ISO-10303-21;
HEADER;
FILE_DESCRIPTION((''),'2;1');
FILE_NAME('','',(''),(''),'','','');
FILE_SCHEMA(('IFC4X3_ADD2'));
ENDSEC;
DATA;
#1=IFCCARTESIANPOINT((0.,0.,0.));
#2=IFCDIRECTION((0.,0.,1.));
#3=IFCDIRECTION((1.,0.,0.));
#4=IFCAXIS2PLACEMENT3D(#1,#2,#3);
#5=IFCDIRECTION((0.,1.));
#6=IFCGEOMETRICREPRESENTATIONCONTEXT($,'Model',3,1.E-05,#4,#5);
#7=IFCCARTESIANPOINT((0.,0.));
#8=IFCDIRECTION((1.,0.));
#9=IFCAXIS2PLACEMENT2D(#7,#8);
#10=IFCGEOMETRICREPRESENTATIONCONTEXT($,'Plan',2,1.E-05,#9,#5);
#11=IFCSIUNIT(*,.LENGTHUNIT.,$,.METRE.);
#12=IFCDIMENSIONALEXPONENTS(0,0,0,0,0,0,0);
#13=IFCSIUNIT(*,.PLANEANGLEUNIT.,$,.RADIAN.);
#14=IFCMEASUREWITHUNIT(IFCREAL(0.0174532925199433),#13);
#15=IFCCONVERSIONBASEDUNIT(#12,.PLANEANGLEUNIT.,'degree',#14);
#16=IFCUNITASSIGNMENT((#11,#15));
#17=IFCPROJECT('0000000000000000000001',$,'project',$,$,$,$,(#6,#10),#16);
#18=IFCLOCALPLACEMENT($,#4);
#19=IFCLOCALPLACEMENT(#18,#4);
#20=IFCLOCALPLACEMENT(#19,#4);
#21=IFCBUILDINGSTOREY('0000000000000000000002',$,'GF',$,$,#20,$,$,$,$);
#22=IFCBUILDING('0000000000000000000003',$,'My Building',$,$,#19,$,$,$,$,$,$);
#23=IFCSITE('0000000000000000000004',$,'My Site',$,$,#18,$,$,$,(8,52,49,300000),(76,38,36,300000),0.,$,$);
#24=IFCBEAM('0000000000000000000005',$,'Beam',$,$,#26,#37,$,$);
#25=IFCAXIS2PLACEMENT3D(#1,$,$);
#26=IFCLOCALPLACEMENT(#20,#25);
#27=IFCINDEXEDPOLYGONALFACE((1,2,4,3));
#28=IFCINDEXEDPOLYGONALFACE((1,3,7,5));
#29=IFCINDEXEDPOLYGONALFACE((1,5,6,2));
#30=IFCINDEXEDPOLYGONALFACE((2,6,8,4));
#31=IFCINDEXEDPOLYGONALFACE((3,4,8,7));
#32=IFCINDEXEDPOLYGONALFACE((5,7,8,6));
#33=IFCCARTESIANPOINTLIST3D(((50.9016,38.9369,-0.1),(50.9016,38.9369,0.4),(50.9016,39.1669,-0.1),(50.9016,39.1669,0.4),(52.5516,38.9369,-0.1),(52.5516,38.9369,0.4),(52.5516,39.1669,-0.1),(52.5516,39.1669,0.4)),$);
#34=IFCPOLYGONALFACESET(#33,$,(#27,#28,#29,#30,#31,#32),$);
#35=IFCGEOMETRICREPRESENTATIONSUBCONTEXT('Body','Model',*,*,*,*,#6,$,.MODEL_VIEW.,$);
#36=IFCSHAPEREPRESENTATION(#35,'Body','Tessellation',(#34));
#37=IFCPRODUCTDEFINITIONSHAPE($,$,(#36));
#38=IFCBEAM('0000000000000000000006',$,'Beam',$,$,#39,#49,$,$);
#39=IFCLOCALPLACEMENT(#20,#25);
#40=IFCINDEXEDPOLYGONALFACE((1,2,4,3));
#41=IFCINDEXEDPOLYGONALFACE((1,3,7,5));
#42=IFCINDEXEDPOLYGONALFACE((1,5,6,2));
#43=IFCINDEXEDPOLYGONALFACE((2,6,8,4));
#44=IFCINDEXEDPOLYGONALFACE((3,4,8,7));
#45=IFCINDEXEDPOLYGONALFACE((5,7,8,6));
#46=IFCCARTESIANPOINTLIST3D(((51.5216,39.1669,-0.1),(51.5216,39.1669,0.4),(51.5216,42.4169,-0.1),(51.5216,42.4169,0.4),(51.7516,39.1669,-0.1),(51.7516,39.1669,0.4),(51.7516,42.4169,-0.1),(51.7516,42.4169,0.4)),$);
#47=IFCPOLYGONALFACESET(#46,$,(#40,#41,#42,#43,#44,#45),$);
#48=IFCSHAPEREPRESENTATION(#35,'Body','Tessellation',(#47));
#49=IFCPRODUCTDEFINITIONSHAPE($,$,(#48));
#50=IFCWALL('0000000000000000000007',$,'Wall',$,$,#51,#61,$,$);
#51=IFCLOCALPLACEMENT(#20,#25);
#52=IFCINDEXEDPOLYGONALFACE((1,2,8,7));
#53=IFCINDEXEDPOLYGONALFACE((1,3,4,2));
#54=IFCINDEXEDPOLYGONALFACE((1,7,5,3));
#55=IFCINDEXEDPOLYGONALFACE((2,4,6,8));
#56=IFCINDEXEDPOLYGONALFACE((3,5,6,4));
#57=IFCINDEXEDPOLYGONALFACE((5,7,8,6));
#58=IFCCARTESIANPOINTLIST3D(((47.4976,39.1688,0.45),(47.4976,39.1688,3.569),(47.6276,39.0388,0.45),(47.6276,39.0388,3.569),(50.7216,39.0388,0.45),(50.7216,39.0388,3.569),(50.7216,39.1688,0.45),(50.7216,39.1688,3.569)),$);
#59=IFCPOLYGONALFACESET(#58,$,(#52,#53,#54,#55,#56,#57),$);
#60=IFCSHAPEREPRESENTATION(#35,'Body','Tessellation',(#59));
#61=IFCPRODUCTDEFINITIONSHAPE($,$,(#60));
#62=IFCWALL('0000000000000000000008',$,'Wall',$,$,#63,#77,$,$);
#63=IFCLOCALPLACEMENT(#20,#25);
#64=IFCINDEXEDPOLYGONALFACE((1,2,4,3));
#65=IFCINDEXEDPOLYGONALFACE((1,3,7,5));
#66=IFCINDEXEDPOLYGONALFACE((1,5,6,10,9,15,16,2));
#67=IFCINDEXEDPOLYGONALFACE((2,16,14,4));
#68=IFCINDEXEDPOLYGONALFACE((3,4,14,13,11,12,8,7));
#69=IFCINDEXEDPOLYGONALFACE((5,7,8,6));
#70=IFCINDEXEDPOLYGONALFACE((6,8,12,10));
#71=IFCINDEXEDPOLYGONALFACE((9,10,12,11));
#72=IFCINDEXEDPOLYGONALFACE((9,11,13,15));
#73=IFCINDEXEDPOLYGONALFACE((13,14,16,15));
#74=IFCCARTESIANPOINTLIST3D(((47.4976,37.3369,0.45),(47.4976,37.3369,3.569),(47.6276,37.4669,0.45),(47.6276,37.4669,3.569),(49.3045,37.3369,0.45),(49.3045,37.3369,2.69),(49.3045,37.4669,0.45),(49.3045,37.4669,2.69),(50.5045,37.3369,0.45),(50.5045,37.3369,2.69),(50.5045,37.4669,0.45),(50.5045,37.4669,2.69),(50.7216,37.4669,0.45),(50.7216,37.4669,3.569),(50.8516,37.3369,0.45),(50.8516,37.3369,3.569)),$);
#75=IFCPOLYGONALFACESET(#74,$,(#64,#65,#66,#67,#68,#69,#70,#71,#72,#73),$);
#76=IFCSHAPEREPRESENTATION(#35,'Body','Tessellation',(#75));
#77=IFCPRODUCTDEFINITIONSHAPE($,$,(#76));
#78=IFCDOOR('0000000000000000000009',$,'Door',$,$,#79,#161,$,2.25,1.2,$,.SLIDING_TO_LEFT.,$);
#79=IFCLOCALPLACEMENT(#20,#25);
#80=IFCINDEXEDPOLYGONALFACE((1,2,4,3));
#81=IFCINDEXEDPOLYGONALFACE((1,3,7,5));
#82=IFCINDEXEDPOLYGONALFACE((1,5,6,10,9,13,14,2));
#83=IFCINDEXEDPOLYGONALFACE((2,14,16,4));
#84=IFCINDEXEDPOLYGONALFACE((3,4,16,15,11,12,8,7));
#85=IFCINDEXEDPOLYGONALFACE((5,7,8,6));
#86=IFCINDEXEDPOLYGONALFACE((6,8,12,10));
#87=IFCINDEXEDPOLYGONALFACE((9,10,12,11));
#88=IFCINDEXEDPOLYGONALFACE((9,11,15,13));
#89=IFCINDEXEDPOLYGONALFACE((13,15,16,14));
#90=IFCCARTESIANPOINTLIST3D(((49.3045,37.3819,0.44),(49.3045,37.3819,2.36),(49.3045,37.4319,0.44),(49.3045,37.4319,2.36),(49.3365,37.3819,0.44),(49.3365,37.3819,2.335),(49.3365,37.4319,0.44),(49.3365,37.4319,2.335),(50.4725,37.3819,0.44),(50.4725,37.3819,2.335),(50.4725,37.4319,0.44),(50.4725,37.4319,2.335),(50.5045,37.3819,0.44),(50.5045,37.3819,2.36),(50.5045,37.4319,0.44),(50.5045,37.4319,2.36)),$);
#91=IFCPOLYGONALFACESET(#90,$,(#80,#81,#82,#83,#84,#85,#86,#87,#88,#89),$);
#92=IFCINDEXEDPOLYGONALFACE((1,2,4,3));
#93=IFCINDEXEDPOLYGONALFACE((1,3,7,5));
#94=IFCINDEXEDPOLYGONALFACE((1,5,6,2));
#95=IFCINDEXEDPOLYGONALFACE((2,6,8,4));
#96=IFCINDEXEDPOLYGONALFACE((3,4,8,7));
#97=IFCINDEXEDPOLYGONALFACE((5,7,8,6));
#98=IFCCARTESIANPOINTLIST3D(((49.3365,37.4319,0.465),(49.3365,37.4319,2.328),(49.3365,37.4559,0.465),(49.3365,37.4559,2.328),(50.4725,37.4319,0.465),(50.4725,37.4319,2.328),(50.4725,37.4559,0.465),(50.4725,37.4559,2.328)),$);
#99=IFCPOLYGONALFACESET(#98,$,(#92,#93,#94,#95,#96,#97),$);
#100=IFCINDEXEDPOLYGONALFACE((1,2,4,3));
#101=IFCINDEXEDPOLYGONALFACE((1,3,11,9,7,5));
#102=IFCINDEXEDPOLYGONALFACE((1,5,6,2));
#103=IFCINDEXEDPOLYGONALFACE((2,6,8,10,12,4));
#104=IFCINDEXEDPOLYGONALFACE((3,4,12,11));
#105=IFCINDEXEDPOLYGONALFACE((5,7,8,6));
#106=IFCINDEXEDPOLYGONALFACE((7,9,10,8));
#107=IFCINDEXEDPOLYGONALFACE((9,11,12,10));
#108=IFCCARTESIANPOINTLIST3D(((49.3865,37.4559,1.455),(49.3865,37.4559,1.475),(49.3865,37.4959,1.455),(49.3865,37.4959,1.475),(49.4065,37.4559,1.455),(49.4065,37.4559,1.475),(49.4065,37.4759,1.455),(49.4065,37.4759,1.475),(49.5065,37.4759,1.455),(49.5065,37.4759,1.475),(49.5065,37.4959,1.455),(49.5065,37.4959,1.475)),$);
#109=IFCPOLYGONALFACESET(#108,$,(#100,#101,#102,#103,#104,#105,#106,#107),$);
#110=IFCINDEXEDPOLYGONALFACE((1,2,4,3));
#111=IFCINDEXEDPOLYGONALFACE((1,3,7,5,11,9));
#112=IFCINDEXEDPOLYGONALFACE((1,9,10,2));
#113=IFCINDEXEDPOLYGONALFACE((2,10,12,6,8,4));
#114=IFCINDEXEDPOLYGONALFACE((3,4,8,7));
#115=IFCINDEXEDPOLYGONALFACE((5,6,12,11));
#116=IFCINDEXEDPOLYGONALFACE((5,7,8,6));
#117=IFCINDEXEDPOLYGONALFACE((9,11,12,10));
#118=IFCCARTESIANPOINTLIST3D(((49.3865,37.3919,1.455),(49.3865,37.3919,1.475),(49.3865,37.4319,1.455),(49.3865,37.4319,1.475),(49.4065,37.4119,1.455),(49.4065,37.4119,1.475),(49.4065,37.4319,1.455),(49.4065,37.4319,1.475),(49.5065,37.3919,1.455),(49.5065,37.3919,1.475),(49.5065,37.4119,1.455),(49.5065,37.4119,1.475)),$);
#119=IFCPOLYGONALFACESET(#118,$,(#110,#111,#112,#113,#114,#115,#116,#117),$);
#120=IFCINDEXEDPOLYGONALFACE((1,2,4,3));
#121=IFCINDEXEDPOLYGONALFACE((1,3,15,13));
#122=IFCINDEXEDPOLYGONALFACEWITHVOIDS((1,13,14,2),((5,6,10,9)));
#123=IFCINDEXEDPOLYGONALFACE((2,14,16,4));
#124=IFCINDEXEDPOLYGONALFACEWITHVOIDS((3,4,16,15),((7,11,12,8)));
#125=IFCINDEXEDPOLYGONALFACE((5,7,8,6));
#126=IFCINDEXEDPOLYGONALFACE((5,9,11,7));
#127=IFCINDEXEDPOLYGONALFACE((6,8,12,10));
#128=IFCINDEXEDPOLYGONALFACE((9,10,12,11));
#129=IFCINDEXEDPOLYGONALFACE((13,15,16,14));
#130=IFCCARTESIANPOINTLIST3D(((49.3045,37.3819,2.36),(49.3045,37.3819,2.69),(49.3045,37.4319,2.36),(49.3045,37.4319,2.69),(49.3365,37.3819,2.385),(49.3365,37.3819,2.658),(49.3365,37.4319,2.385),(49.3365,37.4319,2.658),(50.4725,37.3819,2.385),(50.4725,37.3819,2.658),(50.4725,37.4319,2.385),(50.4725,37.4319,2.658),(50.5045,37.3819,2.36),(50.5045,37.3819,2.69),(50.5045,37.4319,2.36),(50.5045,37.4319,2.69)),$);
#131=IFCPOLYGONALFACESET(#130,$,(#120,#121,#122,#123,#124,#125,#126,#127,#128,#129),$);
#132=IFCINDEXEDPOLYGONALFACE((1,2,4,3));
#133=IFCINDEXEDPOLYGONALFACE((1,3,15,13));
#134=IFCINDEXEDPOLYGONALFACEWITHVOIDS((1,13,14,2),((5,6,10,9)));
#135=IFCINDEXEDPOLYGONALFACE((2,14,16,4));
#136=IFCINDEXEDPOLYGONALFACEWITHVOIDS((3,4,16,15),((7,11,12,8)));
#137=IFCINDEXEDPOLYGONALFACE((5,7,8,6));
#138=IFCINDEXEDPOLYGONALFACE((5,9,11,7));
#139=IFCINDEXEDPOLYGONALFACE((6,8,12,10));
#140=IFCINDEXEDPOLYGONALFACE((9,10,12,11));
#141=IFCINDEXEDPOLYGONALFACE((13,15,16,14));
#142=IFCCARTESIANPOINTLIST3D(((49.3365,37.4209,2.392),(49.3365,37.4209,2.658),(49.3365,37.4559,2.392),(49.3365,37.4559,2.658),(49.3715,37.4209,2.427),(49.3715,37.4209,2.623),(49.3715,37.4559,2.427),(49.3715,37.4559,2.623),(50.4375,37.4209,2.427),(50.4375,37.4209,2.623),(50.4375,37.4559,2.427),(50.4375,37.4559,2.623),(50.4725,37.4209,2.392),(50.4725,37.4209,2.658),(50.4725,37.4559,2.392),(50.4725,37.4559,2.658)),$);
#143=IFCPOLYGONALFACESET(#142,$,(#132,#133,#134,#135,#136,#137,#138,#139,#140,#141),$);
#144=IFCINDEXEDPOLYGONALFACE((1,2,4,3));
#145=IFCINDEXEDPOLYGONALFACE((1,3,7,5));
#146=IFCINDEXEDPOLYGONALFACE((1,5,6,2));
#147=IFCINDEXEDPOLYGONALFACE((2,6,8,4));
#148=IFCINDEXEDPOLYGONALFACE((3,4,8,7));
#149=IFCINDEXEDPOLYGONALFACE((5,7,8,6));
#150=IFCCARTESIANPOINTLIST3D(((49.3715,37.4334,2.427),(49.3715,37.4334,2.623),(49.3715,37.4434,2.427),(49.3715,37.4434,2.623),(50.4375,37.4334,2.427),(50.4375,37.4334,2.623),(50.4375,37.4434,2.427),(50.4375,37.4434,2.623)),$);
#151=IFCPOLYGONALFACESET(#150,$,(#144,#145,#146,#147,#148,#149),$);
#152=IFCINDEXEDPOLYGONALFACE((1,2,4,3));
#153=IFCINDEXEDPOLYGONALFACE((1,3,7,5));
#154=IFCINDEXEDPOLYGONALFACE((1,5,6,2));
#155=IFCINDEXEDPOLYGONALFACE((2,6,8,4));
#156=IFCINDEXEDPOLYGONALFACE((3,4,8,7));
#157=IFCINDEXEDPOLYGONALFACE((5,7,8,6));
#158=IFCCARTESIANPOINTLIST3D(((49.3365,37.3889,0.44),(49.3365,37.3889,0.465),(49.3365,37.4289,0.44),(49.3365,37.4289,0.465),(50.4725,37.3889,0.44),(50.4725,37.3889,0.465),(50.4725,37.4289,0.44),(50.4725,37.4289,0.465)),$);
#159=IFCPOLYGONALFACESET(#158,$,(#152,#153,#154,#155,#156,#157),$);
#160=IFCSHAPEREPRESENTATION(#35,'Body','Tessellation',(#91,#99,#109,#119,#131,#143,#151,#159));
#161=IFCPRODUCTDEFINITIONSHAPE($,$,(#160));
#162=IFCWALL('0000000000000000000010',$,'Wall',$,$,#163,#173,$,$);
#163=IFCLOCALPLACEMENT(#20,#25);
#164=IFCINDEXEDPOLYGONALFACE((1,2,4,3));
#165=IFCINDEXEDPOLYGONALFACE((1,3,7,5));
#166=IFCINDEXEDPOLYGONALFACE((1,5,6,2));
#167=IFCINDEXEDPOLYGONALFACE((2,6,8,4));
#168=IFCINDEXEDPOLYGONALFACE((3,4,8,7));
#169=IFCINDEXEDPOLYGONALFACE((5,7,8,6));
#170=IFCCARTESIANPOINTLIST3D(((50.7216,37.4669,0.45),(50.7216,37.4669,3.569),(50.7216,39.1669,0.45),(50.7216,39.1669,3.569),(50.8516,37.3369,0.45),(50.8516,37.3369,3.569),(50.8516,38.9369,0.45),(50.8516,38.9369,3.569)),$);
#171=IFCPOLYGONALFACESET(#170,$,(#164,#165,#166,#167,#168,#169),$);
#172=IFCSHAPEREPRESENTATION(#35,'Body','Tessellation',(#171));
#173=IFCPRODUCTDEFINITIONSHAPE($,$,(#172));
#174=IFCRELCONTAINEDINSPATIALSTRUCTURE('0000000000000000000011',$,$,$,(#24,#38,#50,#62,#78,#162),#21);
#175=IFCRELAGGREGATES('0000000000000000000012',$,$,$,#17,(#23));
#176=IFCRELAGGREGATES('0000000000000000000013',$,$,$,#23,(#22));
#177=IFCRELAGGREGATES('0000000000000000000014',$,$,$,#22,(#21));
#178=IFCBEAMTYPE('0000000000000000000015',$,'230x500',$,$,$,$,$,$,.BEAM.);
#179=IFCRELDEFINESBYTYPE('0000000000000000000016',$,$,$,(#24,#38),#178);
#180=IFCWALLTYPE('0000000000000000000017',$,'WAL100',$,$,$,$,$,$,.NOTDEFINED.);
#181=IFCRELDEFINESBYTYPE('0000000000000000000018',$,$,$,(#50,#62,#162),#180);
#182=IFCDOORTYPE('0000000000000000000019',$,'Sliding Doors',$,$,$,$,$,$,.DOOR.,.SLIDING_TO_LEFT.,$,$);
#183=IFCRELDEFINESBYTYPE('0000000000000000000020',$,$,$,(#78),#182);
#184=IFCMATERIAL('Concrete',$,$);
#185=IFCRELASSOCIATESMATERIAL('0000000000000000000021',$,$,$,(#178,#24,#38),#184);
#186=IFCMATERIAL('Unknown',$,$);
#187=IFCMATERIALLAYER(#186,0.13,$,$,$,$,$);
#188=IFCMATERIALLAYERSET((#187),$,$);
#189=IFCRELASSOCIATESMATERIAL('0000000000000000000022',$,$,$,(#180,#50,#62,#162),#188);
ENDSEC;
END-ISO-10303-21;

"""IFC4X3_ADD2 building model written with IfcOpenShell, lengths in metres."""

from ifc_helpers import new_model, entity, si_unit, converted_unit, direction, frame, origin_with_axes, origin_2d_with_axis, place, context, subcontext, project, spatial, line, indexed_curve, rectangle, outline, extrude, shape, source, transform, mapped, material, layer, layer_set, layer_usage, material_profile, profile_set, profile_usage, type_object, type_shapes, element, fill, save


model = new_model("IFC4X3_ADD2")

# Units and contexts
model_context = context("Model", 3, precision=1e-05, world=origin_with_axes(), true_north=direction((0.0, 1.0)))
plan_context = context("Plan", 2, precision=1e-05, world=origin_2d_with_axis(), true_north=direction((0.0, 1.0)))
body_context_1 = subcontext(model_context, "Body", "Model", "MODEL_VIEW")
body_context_2 = subcontext(plan_context, "Body", "Plan", "PLAN_VIEW")
ifc_project = project(units=[si_unit("LENGTHUNIT", "METRE"), converted_unit("PLANEANGLEUNIT", "degree", entity("IfcReal", 0.0174532925199433), si_unit("PLANEANGLEUNIT", "RADIAN"), dimensions=[0, 0, 0, 0, 0, 0, 0])], contexts=[model_context, plan_context])

# Site, building, storey
site_placement = place(None, origin_with_axes())
site = spatial("IfcSite", under=ifc_project, at=site_placement, Name="My Site", RefLatitude=(8, 52, 49, 300000), RefLongitude=(76, 38, 36, 300000), RefElevation=0.0)
building_placement = place(site_placement, origin_with_axes())
building = spatial("IfcBuilding", under=site, at=building_placement, Name="My Building")
storey_placement = place(building_placement, origin_with_axes())
storey = spatial("IfcBuildingStorey", under=building, at=storey_placement, Name="GF")

# Beams
ifc_material_1 = material(Name="Concrete")
ifc_material_profile_1 = material_profile(ifc_material_1, rectangle(XDim=0.23, YDim=0.5))
ifc_profile_set_1 = profile_set([ifc_material_profile_1])
ifc_profile_usage_1 = profile_usage(ifc_profile_set_1, cardinal=5)
beam_type = type_object("IfcBeamType", Name="230x500", PredefinedType="BEAM", material=ifc_profile_set_1)
beam_1_placement = place(storey_placement, frame((50.9016, 39.0519, 0.15), z_axis=(1.0, 0.0, 0.0), x_axis=(0.0, 1.0, 0.0)))
element("IfcBeam", 1, at=beam_1_placement, inside=storey, type_object=beam_type, material=ifc_profile_usage_1, Name="Beam", context=body_context_1, shape_type="SweptSolid", body=[
    extrude(rectangle(XDim=0.23, YDim=0.5), origin_with_axes(), (0.0, 0.0, 1.0), 1.65),
])
ifc_profile_usage_2 = profile_usage(ifc_profile_set_1, cardinal=5)
beam_2_placement = place(storey_placement, frame((51.6366, 39.1669, 0.15), z_axis=(0.0, 1.0, 0.0), x_axis=(-1.0, 0.0, 0.0)))
element("IfcBeam", 2, at=beam_2_placement, inside=storey, type_object=beam_type, material=ifc_profile_usage_2, Name="Beam", context=body_context_1, shape_type="SweptSolid", body=[
    extrude(rectangle(XDim=0.23, YDim=0.5), origin_with_axes(), (0.0, 0.0, 1.0), 3.25),
])

# Wall
ifc_material_2 = material(Name="Unknown")
ifc_layer_1 = layer(ifc_material_2, 0.13)
ifc_layer_set_1 = layer_set([ifc_layer_1])
ifc_layer_usage_1 = layer_usage(ifc_layer_set_1, "AXIS2", "POSITIVE", 0.0)
wall_type_1 = type_object("IfcWallType", Name="WAL100", PredefinedType="NOTDEFINED", material=ifc_layer_set_1)
wall_1_placement = place(storey_placement, frame((50.7216, 39.1688, 0.45), z_axis=(0.0, 0.0, 1.0), x_axis=(-1.0, 0.000001, 0.0)))
element("IfcWall", 3, at=wall_1_placement, inside=storey, type_object=wall_type_1, material=ifc_layer_usage_1, Name="Wall", context=body_context_1, shape_type="SweptSolid", body=[
    extrude(outline(indexed_curve([(0.0, 0.0), (0.0, 0.13), (3.0941, 0.13), (3.2241, 0.0)], segments=[line(1, 2, 3, 4, 1)])), origin_with_axes(), (0.0, 0.0, 1.0), 3.119),
])

# Wall, opening, door
ifc_layer_usage_2 = layer_usage(ifc_layer_set_1, "AXIS2", "NEGATIVE", 0.0)
wall_2_placement = place(storey_placement, frame((50.7216, 37.3369, 0.45), z_axis=(0.0, 0.0, 1.0), x_axis=(-1.0, 0.000001, 0.0)))
wall_2 = element("IfcWall", 4, at=wall_2_placement, inside=storey, type_object=wall_type_1, material=ifc_layer_usage_2, Name="Wall", context=body_context_1, shape_type="SweptSolid", body=[
    extrude(outline(indexed_curve([(0.0, -0.13), (-0.13, 0.0), (3.2241, 0.0), (3.0941, -0.13)], segments=[line(1, 2, 3, 4, 1)])), origin_with_axes(), (0.0, 0.0, 1.0), 3.119),
])
shared_shape_1 = source(origin_with_axes(), body_context_1, "Body", "SweptSolid", [
    extrude(outline(indexed_curve([(0.0, 0.0), (1.2, 0.0), (1.2, 2.25), (0.0, 2.25)], segments=[line(1, 2, 3, 4, 1)])), frame((0.0, -0.6, 0.0), z_axis=(0.0, -1.0, 0.0), x_axis=(1.0, 0.0, 0.0)), (0.0, 0.0, -1.0), 1.2),
])
opening_1_placement = place(wall_2_placement, frame((0.2172, -0.13, -0.01), z_axis=(0.0, 0.0, 1.0), x_axis=(1.0, 0.0, 0.0)))
opening_1 = element("IfcOpeningElement", 5, at=opening_1_placement, cuts=wall_2, PredefinedType="OPENING", context=body_context_1, shape_type="MappedRepresentation", body=[
    mapped(shared_shape_1, transform((0.0, 0.0, 0.0), x_axis=(1.0, 0.0, 0.0), y_axis=(0.0, 1.0, 0.0), z_axis=(0.0, 0.0, 1.0), scale=1.0)),
])
door_type = type_object("IfcDoorType", Name="Sliding Doors", OperationType="SLIDING_TO_LEFT", PredefinedType="DOOR")
shared_shape_2 = source(origin_with_axes(), body_context_1, "Body", "SweptSolid", [
    extrude(outline(indexed_curve([(0.0, 0.0), (0.0, 1.92), (1.2, 1.92), (1.2, 0.0), (1.168, 0.0), (1.168, 1.895), (0.032, 1.895), (0.032, 0.0)], segments=[line(1, 2, 3, 4, 5, 6, 7, 8, 1)])), frame((0.0, 0.035, 0.0), z_axis=(0.0, -1.0, 0.0), x_axis=(1.0, 0.0, 0.0)), (0.0, 0.0, -1.0), 0.05),
    extrude(outline(indexed_curve([(0.0, 0.0), (1.136, 0.0), (1.136, 0.024), (0.0, 0.024)], segments=[line(1, 2, 3, 4, 1)])), frame((0.032, 0.011, 0.025), z_axis=(0.0, 0.0, 1.0), x_axis=(1.0, 0.0, 0.0)), (0.0, 0.0, 1.0), 1.863),
    extrude(outline(indexed_curve([(0.0, 0.0), (0.0, -0.04), (-0.12, -0.04), (-0.12, -0.02), (-0.02, -0.02), (-0.02, 0.0)], segments=[line(1, 2, 3, 4, 5, 6, 1)])), frame((1.118, 0.011, 1.015), z_axis=(0.0, 0.0, 1.0), x_axis=(1.0, 0.0, 0.0)), (0.0, 0.0, 1.0), 0.02),
    extrude(outline(indexed_curve([(0.0, 0.0), (0.0, 0.04), (-0.12, 0.04), (-0.12, 0.02), (-0.02, 0.02), (-0.02, 0.0)], segments=[line(1, 2, 3, 4, 5, 6, 1)])), frame((1.118, 0.035, 1.015), z_axis=(0.0, 0.0, 1.0), x_axis=(1.0, 0.0, 0.0)), (0.0, 0.0, 1.0), 0.02),
    extrude(outline(indexed_curve([(0.0, 0.0), (1.2, 0.0), (1.2, 0.33), (0.0, 0.33)], segments=[line(1, 2, 3, 4, 1)]), holes=[indexed_curve([(0.032, 0.025), (1.168, 0.025), (1.168, 0.298), (0.032, 0.298)], segments=[line(1, 2, 3, 4, 1)])]), frame((0.0, 0.035, 1.92), z_axis=(0.0, -1.0, 0.0), x_axis=(1.0, 0.0, 0.0)), (0.0, 0.0, -1.0), 0.05),
    extrude(outline(indexed_curve([(0.0, 0.0), (1.136, 0.0), (1.136, 0.266), (0.0, 0.266)], segments=[line(1, 2, 3, 4, 1)]), holes=[indexed_curve([(0.035, 0.035), (1.101, 0.035), (1.101, 0.231), (0.035, 0.231)], segments=[line(1, 2, 3, 4, 1)])]), frame((0.032, 0.011, 1.952), z_axis=(0.0, -1.0, 0.0), x_axis=(1.0, 0.0, 0.0)), (0.0, 0.0, -1.0), 0.035),
    extrude(outline(indexed_curve([(0.035, 0.035), (1.101, 0.035), (1.101, 0.231), (0.035, 0.231)], segments=[line(1, 2, 3, 4, 1)])), frame((0.032, 0.0235, 1.952), z_axis=(0.0, -1.0, 0.0), x_axis=(1.0, 0.0, 0.0)), (0.0, 0.0, -1.0), 0.01),
    extrude(outline(indexed_curve([(0.0, 0.0), (1.136, 0.0), (1.136, 0.04), (0.0, 0.04)], segments=[line(1, 2, 3, 4, 1)])), frame((0.032, 0.038, 0.0), z_axis=(0.0, 0.0, 1.0), x_axis=(1.0, 0.0, 0.0)), (0.0, 0.0, 1.0), 0.025),
])
shared_shape_3 = source(origin_with_axes(), body_context_2, "Body", "Curve2D", [
    entity("IfcIndexedPolyCurve", entity("IfcCartesianPointList2D", [[0.0, 0.035], [0.032, 0.035], [0.032, 0.085], [0.0, 0.085]]), [entity("IfcLineIndex", [1, 2, 3, 4, 1])]),
    entity("IfcIndexedPolyCurve", entity("IfcCartesianPointList2D", [[1.2, 0.035], [1.168, 0.035], [1.168, 0.085], [1.2, 0.085]]), [entity("IfcLineIndex", [1, 2, 3, 4, 1])]),
    entity("IfcIndexedPolyCurve", entity("IfcCartesianPointList2D", [[-0.536, 0.011], [0.6, 0.011], [0.6, 0.035], [-0.536, 0.035]]), [entity("IfcLineIndex", [1, 2, 3, 4, 1])]),
])
type_shapes(door_type, [shared_shape_2, shared_shape_3])
door_placement = place(opening_1_placement, origin_with_axes())
door = element("IfcDoor", 6, at=door_placement, inside=storey, type_object=door_type, Name="Door", OperationType="SLIDING_TO_LEFT", OverallHeight=2.25, OverallWidth=1.2, shapes=[
    shape(body_context_1, "Body", "MappedRepresentation", [mapped(shared_shape_2, transform((0.0, 0.0, 0.0), x_axis=(1.0, 0.0, 0.0), y_axis=(0.0, 1.0, 0.0), z_axis=(0.0, 0.0, 1.0), scale=1.0))]),
    shape(body_context_2, "Body", "MappedRepresentation", [mapped(shared_shape_3, transform((0.0, 0.0, 0.0), x_axis=(1.0, 0.0, 0.0), y_axis=(0.0, 1.0, 0.0), z_axis=(0.0, 0.0, 1.0), scale=1.0))]),
])
fill(opening_1, door)

# Wall
ifc_layer_usage_3 = layer_usage(ifc_layer_set_1, "AXIS2", "POSITIVE", 0.0)
wall_3_placement = place(storey_placement, frame((50.7216, 38.9369, 0.45), z_axis=(0.0, 0.0, 1.0), x_axis=(-0.000001, -1.0, 0.0)))
element("IfcWall", 7, at=wall_3_placement, inside=storey, type_object=wall_type_1, material=ifc_layer_usage_3, Name="Wall", context=body_context_1, shape_type="SweptSolid", body=[
    extrude(outline(indexed_curve([(-0.23, 0.0), (0.0, 0.13), (1.6, 0.13), (1.47, 0.0)], segments=[line(1, 2, 3, 4, 1)])), origin_with_axes(), (0.0, 0.0, 1.0), 3.119),
])

save(model, "model.ifc")
